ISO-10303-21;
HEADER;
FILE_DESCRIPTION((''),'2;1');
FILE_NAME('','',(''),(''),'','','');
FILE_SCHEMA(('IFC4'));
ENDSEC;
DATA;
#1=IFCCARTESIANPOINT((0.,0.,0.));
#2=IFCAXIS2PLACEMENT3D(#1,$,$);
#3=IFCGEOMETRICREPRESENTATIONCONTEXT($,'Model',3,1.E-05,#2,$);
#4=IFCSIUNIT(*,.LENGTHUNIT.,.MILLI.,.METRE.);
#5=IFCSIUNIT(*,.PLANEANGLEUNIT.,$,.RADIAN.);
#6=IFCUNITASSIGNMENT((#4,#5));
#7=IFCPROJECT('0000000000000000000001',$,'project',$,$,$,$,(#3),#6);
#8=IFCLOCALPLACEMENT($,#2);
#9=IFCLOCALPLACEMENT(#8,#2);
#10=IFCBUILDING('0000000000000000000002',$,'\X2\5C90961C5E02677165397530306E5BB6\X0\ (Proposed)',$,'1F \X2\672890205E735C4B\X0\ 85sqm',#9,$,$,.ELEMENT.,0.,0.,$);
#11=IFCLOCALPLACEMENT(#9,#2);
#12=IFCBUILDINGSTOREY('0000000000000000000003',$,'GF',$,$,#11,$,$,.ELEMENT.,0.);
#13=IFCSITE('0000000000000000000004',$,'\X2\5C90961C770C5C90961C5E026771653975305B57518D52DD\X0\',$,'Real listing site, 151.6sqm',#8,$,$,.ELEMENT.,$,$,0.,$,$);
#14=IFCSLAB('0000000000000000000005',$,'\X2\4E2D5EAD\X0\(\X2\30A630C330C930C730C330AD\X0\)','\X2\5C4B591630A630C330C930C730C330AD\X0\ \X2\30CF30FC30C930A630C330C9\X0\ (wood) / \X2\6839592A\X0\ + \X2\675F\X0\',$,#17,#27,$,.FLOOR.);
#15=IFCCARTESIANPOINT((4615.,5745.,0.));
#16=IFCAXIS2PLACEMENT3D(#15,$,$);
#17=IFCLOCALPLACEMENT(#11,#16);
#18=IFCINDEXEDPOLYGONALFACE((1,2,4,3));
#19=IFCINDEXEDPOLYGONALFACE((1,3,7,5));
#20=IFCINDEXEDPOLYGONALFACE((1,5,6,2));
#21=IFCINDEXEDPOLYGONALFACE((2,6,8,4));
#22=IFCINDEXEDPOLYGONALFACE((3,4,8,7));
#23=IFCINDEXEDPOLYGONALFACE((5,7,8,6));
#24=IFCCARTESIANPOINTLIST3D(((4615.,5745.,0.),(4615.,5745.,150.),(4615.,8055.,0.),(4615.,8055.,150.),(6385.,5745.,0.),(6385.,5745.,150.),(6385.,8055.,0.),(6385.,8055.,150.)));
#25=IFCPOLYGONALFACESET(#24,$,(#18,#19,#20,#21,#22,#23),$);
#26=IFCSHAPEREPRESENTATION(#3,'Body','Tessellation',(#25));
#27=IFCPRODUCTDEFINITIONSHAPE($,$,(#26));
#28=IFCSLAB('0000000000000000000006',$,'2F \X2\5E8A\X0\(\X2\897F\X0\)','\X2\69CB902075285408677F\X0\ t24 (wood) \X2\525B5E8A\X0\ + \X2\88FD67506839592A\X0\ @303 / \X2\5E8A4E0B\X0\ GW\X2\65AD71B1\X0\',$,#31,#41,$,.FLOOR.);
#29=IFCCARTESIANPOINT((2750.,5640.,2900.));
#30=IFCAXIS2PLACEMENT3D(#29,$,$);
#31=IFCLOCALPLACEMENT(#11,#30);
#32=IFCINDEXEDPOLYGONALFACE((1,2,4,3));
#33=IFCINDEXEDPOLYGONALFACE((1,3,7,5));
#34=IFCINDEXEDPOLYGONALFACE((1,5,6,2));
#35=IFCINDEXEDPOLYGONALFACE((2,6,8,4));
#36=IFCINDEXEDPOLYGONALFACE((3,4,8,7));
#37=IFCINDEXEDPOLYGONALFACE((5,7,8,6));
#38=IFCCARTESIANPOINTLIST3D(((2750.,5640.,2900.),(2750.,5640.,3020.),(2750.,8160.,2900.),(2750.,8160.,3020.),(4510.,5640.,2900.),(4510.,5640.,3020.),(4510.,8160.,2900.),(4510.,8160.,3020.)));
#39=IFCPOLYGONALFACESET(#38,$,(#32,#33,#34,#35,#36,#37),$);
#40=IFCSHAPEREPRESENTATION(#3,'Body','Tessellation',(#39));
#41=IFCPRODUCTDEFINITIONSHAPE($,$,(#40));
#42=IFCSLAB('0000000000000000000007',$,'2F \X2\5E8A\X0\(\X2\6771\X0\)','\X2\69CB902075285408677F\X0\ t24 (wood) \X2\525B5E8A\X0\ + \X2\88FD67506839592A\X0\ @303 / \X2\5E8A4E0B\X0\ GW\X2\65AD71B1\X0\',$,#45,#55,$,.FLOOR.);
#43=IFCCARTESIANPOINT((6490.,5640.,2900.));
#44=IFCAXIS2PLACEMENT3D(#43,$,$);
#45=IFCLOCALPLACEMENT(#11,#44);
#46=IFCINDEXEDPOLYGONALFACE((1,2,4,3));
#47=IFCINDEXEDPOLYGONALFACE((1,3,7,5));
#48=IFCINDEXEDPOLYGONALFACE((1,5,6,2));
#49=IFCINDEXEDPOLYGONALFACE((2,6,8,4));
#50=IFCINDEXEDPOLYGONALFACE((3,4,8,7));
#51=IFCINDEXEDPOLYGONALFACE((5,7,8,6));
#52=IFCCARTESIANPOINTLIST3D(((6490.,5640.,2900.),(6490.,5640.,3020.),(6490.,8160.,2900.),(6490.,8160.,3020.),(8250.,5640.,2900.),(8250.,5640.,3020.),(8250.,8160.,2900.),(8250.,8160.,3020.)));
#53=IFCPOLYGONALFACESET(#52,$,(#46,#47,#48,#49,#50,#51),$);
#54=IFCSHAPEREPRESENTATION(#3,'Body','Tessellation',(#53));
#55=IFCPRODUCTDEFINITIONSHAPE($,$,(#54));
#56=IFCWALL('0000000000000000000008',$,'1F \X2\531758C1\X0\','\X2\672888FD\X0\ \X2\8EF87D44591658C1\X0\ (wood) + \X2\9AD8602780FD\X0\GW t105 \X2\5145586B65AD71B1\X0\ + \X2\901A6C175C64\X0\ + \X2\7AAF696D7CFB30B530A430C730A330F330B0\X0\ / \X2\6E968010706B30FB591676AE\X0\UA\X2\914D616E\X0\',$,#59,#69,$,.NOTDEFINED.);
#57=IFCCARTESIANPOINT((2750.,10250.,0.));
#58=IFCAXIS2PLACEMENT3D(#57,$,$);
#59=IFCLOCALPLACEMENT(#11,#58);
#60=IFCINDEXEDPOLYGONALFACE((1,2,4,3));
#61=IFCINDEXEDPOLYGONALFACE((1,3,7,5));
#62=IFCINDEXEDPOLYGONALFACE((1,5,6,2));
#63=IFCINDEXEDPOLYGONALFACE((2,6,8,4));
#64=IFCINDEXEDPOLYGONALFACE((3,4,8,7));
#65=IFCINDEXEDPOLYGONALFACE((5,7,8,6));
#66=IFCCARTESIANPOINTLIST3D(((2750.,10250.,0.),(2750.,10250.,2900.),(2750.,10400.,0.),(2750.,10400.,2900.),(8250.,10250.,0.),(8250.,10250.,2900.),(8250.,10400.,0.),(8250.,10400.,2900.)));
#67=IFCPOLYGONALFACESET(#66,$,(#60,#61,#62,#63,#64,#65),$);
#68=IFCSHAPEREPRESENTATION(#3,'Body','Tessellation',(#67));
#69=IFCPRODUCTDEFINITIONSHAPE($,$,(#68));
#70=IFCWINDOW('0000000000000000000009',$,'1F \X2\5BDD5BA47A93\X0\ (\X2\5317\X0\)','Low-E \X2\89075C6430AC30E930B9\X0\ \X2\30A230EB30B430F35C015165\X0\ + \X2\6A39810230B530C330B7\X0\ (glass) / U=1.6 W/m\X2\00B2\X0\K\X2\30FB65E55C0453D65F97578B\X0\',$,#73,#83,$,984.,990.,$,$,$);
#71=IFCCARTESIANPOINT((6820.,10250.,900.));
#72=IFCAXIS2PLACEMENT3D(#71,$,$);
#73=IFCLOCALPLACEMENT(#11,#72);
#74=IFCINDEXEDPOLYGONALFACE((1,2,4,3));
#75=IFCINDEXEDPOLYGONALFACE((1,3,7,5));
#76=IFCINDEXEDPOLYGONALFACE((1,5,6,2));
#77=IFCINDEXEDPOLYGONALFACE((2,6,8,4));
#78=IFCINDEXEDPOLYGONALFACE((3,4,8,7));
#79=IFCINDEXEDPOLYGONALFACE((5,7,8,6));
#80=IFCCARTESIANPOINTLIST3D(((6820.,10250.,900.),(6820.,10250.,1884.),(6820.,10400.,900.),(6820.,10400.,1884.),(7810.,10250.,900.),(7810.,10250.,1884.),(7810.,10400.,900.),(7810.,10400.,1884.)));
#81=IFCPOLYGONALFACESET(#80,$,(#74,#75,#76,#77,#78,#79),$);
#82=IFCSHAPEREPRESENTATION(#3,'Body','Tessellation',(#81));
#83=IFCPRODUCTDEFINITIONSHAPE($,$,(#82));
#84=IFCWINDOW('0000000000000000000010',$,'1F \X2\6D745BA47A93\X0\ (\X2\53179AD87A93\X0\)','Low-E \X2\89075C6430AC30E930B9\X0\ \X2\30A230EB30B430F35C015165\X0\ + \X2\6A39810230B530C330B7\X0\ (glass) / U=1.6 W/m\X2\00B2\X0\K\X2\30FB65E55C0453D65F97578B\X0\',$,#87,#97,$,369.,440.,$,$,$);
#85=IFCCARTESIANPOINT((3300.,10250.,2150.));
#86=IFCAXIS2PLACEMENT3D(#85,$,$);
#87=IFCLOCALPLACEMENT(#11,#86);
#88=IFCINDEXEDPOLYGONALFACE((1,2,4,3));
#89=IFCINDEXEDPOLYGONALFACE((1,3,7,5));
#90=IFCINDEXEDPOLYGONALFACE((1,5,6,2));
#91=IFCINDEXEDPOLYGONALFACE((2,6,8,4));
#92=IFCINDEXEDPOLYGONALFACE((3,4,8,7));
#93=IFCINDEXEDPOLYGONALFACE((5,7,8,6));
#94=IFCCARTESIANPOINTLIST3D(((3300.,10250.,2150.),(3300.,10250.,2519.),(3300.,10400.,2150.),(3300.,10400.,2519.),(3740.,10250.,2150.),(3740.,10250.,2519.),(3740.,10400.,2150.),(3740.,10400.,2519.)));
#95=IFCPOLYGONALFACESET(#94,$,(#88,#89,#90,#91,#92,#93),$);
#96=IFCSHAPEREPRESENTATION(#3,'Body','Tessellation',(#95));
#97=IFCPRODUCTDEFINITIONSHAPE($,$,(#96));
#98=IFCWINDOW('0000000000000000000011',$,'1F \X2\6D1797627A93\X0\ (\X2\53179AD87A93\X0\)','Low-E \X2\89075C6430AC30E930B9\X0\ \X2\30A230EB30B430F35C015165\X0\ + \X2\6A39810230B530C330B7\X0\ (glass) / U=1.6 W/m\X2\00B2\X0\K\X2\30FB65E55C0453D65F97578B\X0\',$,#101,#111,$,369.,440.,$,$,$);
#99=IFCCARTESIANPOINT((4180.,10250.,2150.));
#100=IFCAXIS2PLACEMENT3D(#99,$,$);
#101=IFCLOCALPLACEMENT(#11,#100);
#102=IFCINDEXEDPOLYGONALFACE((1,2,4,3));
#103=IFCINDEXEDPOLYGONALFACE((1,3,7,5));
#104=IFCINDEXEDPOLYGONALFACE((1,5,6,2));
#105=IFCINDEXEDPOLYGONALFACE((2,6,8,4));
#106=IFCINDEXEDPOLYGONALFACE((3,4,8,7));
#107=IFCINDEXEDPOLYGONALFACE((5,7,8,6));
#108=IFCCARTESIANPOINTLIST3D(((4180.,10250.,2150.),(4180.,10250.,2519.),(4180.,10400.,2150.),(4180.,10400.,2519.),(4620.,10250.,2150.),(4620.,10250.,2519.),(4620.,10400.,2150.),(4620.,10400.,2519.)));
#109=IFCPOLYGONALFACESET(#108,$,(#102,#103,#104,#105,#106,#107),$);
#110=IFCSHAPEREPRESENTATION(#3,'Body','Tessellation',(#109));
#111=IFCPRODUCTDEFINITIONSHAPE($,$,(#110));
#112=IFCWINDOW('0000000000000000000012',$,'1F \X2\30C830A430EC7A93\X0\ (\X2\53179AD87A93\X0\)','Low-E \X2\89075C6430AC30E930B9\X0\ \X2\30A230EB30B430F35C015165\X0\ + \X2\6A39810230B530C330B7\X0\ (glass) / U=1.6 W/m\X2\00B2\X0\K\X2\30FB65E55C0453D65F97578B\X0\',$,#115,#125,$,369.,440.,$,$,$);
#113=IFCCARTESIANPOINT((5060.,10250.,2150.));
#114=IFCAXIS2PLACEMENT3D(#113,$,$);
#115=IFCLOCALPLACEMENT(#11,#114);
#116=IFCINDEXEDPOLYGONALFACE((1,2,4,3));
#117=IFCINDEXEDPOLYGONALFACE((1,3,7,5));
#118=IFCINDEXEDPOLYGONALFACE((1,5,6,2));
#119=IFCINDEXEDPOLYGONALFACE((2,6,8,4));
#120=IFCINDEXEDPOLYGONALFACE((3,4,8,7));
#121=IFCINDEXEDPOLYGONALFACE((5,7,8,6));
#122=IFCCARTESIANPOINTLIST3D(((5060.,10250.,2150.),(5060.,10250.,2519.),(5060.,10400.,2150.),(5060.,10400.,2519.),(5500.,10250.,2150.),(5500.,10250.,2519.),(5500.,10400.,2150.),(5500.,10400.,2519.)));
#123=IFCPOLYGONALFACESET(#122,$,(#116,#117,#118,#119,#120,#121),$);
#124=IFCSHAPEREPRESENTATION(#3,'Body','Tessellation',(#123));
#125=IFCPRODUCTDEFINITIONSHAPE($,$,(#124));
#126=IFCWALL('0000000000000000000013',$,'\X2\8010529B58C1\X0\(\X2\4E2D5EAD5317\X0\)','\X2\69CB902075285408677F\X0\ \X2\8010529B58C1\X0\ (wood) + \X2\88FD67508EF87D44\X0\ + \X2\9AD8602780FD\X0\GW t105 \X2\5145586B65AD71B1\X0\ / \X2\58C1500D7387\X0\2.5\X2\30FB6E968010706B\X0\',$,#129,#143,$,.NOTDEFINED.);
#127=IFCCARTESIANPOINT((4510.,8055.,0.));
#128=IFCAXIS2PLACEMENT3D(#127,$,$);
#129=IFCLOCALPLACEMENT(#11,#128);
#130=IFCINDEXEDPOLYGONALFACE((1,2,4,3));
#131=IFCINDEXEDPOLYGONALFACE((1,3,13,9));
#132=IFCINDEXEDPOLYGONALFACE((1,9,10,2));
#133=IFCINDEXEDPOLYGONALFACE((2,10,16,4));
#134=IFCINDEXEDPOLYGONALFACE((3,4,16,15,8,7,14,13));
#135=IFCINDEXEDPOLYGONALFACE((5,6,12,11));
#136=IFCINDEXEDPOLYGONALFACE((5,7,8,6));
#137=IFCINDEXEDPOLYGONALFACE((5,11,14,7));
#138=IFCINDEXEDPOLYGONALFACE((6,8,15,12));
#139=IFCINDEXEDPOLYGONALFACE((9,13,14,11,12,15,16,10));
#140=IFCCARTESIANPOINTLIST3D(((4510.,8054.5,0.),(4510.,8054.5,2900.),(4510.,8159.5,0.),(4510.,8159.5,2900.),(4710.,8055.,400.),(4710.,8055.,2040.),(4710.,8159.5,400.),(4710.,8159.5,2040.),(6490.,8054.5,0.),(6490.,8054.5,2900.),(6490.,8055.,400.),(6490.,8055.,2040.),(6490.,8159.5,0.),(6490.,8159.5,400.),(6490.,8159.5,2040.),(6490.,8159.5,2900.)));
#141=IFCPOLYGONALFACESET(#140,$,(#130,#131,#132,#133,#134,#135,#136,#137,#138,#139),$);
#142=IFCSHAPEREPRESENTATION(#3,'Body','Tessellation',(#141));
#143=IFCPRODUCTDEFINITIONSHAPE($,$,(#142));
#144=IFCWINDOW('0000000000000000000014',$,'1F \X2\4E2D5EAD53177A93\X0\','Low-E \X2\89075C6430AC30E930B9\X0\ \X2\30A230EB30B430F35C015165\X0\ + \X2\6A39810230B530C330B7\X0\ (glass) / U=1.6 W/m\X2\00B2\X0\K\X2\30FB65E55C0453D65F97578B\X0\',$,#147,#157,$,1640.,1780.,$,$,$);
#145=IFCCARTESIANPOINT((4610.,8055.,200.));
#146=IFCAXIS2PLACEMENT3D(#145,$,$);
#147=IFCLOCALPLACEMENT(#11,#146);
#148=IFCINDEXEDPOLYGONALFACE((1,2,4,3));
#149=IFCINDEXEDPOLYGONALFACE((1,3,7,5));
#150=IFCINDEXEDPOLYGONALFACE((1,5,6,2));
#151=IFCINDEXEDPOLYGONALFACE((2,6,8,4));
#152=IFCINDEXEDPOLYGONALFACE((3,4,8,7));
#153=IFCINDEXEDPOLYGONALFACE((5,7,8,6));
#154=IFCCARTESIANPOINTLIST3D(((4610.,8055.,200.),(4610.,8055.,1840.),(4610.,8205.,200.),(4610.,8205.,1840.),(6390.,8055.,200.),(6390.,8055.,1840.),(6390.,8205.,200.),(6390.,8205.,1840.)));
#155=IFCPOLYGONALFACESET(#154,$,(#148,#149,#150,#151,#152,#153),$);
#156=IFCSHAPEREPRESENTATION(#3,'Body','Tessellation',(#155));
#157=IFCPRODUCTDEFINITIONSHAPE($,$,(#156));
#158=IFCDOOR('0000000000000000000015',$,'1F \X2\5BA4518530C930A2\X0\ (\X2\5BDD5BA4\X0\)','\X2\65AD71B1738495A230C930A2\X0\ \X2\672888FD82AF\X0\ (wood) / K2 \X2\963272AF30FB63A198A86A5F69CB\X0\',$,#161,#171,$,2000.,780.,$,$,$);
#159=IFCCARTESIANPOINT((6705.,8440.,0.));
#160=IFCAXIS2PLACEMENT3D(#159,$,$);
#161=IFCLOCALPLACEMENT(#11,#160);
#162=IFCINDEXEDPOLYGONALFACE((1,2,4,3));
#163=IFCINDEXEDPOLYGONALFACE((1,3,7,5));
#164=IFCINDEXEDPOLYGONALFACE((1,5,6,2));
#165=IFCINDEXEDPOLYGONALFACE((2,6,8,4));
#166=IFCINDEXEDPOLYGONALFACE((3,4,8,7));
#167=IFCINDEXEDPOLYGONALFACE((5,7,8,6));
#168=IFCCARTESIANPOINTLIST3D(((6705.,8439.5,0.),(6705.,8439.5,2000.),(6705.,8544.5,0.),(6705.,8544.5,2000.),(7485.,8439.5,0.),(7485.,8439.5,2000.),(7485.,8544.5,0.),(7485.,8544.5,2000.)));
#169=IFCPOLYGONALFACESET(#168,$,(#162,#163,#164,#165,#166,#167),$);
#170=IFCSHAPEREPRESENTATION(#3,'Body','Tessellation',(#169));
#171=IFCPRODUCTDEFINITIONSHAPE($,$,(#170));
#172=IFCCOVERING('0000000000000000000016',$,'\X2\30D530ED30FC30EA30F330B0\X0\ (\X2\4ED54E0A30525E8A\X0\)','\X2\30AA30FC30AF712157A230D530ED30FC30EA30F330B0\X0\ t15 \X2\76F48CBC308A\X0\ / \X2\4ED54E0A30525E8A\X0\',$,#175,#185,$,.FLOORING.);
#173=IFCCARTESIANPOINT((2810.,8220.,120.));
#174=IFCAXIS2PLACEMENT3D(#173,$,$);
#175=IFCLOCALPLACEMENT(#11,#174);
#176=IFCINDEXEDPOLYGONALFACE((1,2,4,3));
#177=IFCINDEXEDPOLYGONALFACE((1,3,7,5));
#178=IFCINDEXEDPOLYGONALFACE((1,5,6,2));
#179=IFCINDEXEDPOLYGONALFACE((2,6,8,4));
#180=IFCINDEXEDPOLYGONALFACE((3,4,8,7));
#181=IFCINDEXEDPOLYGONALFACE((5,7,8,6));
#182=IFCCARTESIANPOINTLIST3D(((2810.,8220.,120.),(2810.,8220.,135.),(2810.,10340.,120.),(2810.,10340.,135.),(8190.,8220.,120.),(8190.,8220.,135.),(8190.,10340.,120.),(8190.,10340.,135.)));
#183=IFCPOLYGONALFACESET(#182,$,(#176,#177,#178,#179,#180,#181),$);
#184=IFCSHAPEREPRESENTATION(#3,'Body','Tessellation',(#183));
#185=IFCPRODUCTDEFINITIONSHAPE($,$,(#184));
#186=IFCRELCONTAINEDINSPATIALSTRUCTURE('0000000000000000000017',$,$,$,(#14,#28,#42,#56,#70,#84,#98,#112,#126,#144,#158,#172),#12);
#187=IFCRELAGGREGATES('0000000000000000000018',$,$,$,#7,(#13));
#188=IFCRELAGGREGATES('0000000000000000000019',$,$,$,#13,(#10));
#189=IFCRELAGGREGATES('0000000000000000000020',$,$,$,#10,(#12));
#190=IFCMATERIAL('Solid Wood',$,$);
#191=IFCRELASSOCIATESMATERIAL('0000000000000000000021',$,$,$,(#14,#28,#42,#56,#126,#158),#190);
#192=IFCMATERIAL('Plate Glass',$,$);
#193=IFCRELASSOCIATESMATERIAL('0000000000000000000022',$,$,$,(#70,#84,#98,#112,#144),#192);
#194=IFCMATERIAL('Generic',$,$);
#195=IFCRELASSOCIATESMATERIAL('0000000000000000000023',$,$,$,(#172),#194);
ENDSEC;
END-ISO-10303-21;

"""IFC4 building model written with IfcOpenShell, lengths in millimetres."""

from ifc_helpers import new_model, si_unit, frame, frame_2d, origin, place, context, project, spatial, rectangle, extrude, material, element, fill, save


model = new_model("IFC4")

# Units and contexts
model_context = context("Model", 3, precision=1e-05, world=origin())
ifc_project = project(units=[si_unit("LENGTHUNIT", "METRE", prefix="MILLI"), si_unit("PLANEANGLEUNIT", "RADIAN")], contexts=[model_context])

# Site, building, storey
site_placement = place(None, origin())
site = spatial("IfcSite", under=ifc_project, at=site_placement, Name="岐阜県岐阜市東改田字再勝", ObjectType="Real listing site, 151.6sqm", CompositionType="ELEMENT", RefElevation=0.0)
building_placement = place(site_placement, origin())
building = spatial("IfcBuilding", under=site, at=building_placement, Name="岐阜市東改田の家 (Proposed)", ObjectType="1F 木造平屋 85sqm", CompositionType="ELEMENT", ElevationOfRefHeight=0.0, ElevationOfTerrain=0.0)
storey_placement = place(building_placement, origin())
storey = spatial("IfcBuildingStorey", under=building, at=storey_placement, Name="GF", CompositionType="ELEMENT", Elevation=0.0)

# Slabs
ifc_material_1 = material(Name="Solid Wood")
slab_1_placement = place(storey_placement, frame((4615.0, 5745.0, 0.0)))
element("IfcSlab", 1, at=slab_1_placement, inside=storey, material=ifc_material_1, Name="中庭(ウッドデッキ)", Description="屋外ウッドデッキ ハードウッド (wood) / 根太 + 束", PredefinedType="FLOOR", context=model_context, shape_type="SweptSolid", body=[
    extrude(rectangle(XDim=1770.0, YDim=2310.0, at=frame_2d((885.0, 1155.0))), frame((4615.0, 5745.0, 0.0)), (0.0, 0.0, 1.0), 150.0),
])
slab_2_placement = place(storey_placement, frame((2750.0, 5640.0, 2900.0)))
element("IfcSlab", 2, at=slab_2_placement, inside=storey, material=ifc_material_1, Name="2F 床(西)", Description="構造用合板 t24 (wood) 剛床 + 製材根太 @303 / 床下 GW断熱", PredefinedType="FLOOR", context=model_context, shape_type="SweptSolid", body=[
    extrude(rectangle(XDim=1760.0, YDim=2520.0, at=frame_2d((880.0, 1260.0))), frame((2750.0, 5640.0, 2900.0)), (0.0, 0.0, 1.0), 120.0),
])
slab_3_placement = place(storey_placement, frame((6490.0, 5640.0, 2900.0)))
element("IfcSlab", 3, at=slab_3_placement, inside=storey, material=ifc_material_1, Name="2F 床(東)", Description="構造用合板 t24 (wood) 剛床 + 製材根太 @303 / 床下 GW断熱", PredefinedType="FLOOR", context=model_context, shape_type="SweptSolid", body=[
    extrude(rectangle(XDim=1760.0, YDim=2520.0, at=frame_2d((880.0, 1260.0))), frame((6490.0, 5640.0, 2900.0)), (0.0, 0.0, 1.0), 120.0),
])

# Wall, openings, windows
wall_1_placement = place(storey_placement, frame((2750.0, 10250.0, 0.0)))
wall_1 = element("IfcWall", 4, at=wall_1_placement, inside=storey, material=ifc_material_1, Name="1F 北壁", Description="木製 軸組外壁 (wood) + 高性能GW t105 充填断熱 + 通気層 + 窯業系サイディング / 準耐火・外皮UA配慮", PredefinedType="NOTDEFINED", context=model_context, shape_type="SweptSolid", body=[
    extrude(rectangle(XDim=5500.0, YDim=150.0, at=frame_2d((2750.0, 75.0))), frame((2750.0, 10250.0, 0.0)), (0.0, 0.0, 1.0), 2900.0),
])
opening_1_placement = place(storey_placement, frame((6820.0, 10250.0, 900.0)))
opening_1 = element("IfcOpeningElement", 5, at=opening_1_placement, cuts=wall_1, PredefinedType="NOTDEFINED", context=model_context, shape_type="SweptSolid", body=[
    extrude(rectangle(XDim=990.0, YDim=150.0, at=frame_2d((495.0, 75.0))), frame((6820.0, 10250.0, 900.0)), (0.0, 0.0, 1.0), 984.0),
])
opening_2_placement = place(storey_placement, frame((3300.0, 10250.0, 2150.0)))
opening_2 = element("IfcOpeningElement", 6, at=opening_2_placement, cuts=wall_1, PredefinedType="NOTDEFINED", context=model_context, shape_type="SweptSolid", body=[
    extrude(rectangle(XDim=440.0, YDim=150.0, at=frame_2d((220.0, 75.0))), frame((3300.0, 10250.0, 2150.0)), (0.0, 0.0, 1.0), 369.0),
])
opening_3_placement = place(storey_placement, frame((4180.0, 10250.0, 2150.0)))
opening_3 = element("IfcOpeningElement", 7, at=opening_3_placement, cuts=wall_1, PredefinedType="NOTDEFINED", context=model_context, shape_type="SweptSolid", body=[
    extrude(rectangle(XDim=440.0, YDim=150.0, at=frame_2d((220.0, 75.0))), frame((4180.0, 10250.0, 2150.0)), (0.0, 0.0, 1.0), 369.0),
])
opening_4_placement = place(storey_placement, frame((5060.0, 10250.0, 2150.0)))
opening_4 = element("IfcOpeningElement", 8, at=opening_4_placement, cuts=wall_1, PredefinedType="NOTDEFINED", context=model_context, shape_type="SweptSolid", body=[
    extrude(rectangle(XDim=440.0, YDim=150.0, at=frame_2d((220.0, 75.0))), frame((5060.0, 10250.0, 2150.0)), (0.0, 0.0, 1.0), 369.0),
])
ifc_material_2 = material(Name="Plate Glass")
window_1_placement = place(storey_placement, frame((6820.0, 10250.0, 900.0)))
window_1 = element("IfcWindow", 9, at=window_1_placement, inside=storey, material=ifc_material_2, Name="1F 寝室窓 (北)", Description="Low-E 複層ガラス アルゴン封入 + 樹脂サッシ (glass) / U=1.6 W/m²K・日射取得型", OverallHeight=984.0, OverallWidth=990.0, context=model_context, shape_type="SweptSolid", body=[
    extrude(rectangle(XDim=990.0, YDim=150.0, at=frame_2d((495.0, 75.0))), frame((6820.0, 10250.0, 900.0)), (0.0, 0.0, 1.0), 984.0),
])
fill(opening_1, window_1)
window_2_placement = place(storey_placement, frame((3300.0, 10250.0, 2150.0)))
window_2 = element("IfcWindow", 10, at=window_2_placement, inside=storey, material=ifc_material_2, Name="1F 浴室窓 (北高窓)", Description="Low-E 複層ガラス アルゴン封入 + 樹脂サッシ (glass) / U=1.6 W/m²K・日射取得型", OverallHeight=369.0, OverallWidth=440.0, context=model_context, shape_type="SweptSolid", body=[
    extrude(rectangle(XDim=440.0, YDim=150.0, at=frame_2d((220.0, 75.0))), frame((3300.0, 10250.0, 2150.0)), (0.0, 0.0, 1.0), 369.0),
])
fill(opening_2, window_2)
window_3_placement = place(storey_placement, frame((4180.0, 10250.0, 2150.0)))
window_3 = element("IfcWindow", 11, at=window_3_placement, inside=storey, material=ifc_material_2, Name="1F 洗面窓 (北高窓)", Description="Low-E 複層ガラス アルゴン封入 + 樹脂サッシ (glass) / U=1.6 W/m²K・日射取得型", OverallHeight=369.0, OverallWidth=440.0, context=model_context, shape_type="SweptSolid", body=[
    extrude(rectangle(XDim=440.0, YDim=150.0, at=frame_2d((220.0, 75.0))), frame((4180.0, 10250.0, 2150.0)), (0.0, 0.0, 1.0), 369.0),
])
fill(opening_3, window_3)
window_4_placement = place(storey_placement, frame((5060.0, 10250.0, 2150.0)))
window_4 = element("IfcWindow", 12, at=window_4_placement, inside=storey, material=ifc_material_2, Name="1F トイレ窓 (北高窓)", Description="Low-E 複層ガラス アルゴン封入 + 樹脂サッシ (glass) / U=1.6 W/m²K・日射取得型", OverallHeight=369.0, OverallWidth=440.0, context=model_context, shape_type="SweptSolid", body=[
    extrude(rectangle(XDim=440.0, YDim=150.0, at=frame_2d((220.0, 75.0))), frame((5060.0, 10250.0, 2150.0)), (0.0, 0.0, 1.0), 369.0),
])
fill(opening_4, window_4)

# Wall, opening, window
wall_2_placement = place(storey_placement, frame((4510.0, 8055.0, 0.0)))
wall_2 = element("IfcWall", 13, at=wall_2_placement, inside=storey, material=ifc_material_1, Name="耐力壁(中庭北)", Description="構造用合板 耐力壁 (wood) + 製材軸組 + 高性能GW t105 充填断熱 / 壁倍率2.5・準耐火", PredefinedType="NOTDEFINED", context=model_context, shape_type="SweptSolid", body=[
    extrude(rectangle(XDim=1980.0, YDim=105.0, at=frame_2d((990.0, 52.0))), frame((4510.0, 8055.0, 0.0)), (0.0, 0.0, 1.0), 2900.0),
])
opening_5_placement = place(storey_placement, frame((4610.0, 8055.0, 200.0)))
opening_5 = element("IfcOpeningElement", 14, at=opening_5_placement, cuts=wall_2, PredefinedType="NOTDEFINED", context=model_context, shape_type="SweptSolid", body=[
    extrude(rectangle(XDim=1780.0, YDim=150.0, at=frame_2d((890.0, 75.0))), frame((4610.0, 8055.0, 200.0)), (0.0, 0.0, 1.0), 1640.0),
])
window_5_placement = place(storey_placement, frame((4610.0, 8055.0, 200.0)))
window_5 = element("IfcWindow", 15, at=window_5_placement, inside=storey, material=ifc_material_2, Name="1F 中庭北窓", Description="Low-E 複層ガラス アルゴン封入 + 樹脂サッシ (glass) / U=1.6 W/m²K・日射取得型", OverallHeight=1640.0, OverallWidth=1780.0, context=model_context, shape_type="SweptSolid", body=[
    extrude(rectangle(XDim=1780.0, YDim=150.0, at=frame_2d((890.0, 75.0))), frame((4610.0, 8055.0, 200.0)), (0.0, 0.0, 1.0), 1640.0),
])
fill(opening_5, window_5)

# Door
door_1_placement = place(storey_placement, frame((6705.0, 8440.0, 0.0)))
element("IfcDoor", 16, at=door_1_placement, inside=storey, material=ifc_material_1, Name="1F 室内ドア (寝室)", Description="断熱玄関ドア 木製芯 (wood) / K2 防犯・採風機構", OverallHeight=2000.0, OverallWidth=780.0, context=model_context, shape_type="SweptSolid", body=[
    extrude(rectangle(XDim=780.0, YDim=105.0, at=frame_2d((390.0, 52.0))), frame((6705.0, 8440.0, 0.0)), (0.0, 0.0, 1.0), 2000.0),
])

# Covering
ifc_material_3 = material(Name="Generic")
covering_1_placement = place(storey_placement, frame((2810.0, 8220.0, 120.0)))
element("IfcCovering", 17, at=covering_1_placement, inside=storey, material=ifc_material_3, Name="フローリング (仕上げ床)", Description="オーク無垢フローリング t15 直貼り / 仕上げ床", PredefinedType="FLOORING", context=model_context, shape_type="SweptSolid", body=[
    extrude(rectangle(XDim=5380.0, YDim=2120.0, at=frame_2d((2690.0, 1060.0))), frame((2810.0, 8220.0, 120.0)), (0.0, 0.0, 1.0), 15.0),
])

save(model, "model.ifc")
